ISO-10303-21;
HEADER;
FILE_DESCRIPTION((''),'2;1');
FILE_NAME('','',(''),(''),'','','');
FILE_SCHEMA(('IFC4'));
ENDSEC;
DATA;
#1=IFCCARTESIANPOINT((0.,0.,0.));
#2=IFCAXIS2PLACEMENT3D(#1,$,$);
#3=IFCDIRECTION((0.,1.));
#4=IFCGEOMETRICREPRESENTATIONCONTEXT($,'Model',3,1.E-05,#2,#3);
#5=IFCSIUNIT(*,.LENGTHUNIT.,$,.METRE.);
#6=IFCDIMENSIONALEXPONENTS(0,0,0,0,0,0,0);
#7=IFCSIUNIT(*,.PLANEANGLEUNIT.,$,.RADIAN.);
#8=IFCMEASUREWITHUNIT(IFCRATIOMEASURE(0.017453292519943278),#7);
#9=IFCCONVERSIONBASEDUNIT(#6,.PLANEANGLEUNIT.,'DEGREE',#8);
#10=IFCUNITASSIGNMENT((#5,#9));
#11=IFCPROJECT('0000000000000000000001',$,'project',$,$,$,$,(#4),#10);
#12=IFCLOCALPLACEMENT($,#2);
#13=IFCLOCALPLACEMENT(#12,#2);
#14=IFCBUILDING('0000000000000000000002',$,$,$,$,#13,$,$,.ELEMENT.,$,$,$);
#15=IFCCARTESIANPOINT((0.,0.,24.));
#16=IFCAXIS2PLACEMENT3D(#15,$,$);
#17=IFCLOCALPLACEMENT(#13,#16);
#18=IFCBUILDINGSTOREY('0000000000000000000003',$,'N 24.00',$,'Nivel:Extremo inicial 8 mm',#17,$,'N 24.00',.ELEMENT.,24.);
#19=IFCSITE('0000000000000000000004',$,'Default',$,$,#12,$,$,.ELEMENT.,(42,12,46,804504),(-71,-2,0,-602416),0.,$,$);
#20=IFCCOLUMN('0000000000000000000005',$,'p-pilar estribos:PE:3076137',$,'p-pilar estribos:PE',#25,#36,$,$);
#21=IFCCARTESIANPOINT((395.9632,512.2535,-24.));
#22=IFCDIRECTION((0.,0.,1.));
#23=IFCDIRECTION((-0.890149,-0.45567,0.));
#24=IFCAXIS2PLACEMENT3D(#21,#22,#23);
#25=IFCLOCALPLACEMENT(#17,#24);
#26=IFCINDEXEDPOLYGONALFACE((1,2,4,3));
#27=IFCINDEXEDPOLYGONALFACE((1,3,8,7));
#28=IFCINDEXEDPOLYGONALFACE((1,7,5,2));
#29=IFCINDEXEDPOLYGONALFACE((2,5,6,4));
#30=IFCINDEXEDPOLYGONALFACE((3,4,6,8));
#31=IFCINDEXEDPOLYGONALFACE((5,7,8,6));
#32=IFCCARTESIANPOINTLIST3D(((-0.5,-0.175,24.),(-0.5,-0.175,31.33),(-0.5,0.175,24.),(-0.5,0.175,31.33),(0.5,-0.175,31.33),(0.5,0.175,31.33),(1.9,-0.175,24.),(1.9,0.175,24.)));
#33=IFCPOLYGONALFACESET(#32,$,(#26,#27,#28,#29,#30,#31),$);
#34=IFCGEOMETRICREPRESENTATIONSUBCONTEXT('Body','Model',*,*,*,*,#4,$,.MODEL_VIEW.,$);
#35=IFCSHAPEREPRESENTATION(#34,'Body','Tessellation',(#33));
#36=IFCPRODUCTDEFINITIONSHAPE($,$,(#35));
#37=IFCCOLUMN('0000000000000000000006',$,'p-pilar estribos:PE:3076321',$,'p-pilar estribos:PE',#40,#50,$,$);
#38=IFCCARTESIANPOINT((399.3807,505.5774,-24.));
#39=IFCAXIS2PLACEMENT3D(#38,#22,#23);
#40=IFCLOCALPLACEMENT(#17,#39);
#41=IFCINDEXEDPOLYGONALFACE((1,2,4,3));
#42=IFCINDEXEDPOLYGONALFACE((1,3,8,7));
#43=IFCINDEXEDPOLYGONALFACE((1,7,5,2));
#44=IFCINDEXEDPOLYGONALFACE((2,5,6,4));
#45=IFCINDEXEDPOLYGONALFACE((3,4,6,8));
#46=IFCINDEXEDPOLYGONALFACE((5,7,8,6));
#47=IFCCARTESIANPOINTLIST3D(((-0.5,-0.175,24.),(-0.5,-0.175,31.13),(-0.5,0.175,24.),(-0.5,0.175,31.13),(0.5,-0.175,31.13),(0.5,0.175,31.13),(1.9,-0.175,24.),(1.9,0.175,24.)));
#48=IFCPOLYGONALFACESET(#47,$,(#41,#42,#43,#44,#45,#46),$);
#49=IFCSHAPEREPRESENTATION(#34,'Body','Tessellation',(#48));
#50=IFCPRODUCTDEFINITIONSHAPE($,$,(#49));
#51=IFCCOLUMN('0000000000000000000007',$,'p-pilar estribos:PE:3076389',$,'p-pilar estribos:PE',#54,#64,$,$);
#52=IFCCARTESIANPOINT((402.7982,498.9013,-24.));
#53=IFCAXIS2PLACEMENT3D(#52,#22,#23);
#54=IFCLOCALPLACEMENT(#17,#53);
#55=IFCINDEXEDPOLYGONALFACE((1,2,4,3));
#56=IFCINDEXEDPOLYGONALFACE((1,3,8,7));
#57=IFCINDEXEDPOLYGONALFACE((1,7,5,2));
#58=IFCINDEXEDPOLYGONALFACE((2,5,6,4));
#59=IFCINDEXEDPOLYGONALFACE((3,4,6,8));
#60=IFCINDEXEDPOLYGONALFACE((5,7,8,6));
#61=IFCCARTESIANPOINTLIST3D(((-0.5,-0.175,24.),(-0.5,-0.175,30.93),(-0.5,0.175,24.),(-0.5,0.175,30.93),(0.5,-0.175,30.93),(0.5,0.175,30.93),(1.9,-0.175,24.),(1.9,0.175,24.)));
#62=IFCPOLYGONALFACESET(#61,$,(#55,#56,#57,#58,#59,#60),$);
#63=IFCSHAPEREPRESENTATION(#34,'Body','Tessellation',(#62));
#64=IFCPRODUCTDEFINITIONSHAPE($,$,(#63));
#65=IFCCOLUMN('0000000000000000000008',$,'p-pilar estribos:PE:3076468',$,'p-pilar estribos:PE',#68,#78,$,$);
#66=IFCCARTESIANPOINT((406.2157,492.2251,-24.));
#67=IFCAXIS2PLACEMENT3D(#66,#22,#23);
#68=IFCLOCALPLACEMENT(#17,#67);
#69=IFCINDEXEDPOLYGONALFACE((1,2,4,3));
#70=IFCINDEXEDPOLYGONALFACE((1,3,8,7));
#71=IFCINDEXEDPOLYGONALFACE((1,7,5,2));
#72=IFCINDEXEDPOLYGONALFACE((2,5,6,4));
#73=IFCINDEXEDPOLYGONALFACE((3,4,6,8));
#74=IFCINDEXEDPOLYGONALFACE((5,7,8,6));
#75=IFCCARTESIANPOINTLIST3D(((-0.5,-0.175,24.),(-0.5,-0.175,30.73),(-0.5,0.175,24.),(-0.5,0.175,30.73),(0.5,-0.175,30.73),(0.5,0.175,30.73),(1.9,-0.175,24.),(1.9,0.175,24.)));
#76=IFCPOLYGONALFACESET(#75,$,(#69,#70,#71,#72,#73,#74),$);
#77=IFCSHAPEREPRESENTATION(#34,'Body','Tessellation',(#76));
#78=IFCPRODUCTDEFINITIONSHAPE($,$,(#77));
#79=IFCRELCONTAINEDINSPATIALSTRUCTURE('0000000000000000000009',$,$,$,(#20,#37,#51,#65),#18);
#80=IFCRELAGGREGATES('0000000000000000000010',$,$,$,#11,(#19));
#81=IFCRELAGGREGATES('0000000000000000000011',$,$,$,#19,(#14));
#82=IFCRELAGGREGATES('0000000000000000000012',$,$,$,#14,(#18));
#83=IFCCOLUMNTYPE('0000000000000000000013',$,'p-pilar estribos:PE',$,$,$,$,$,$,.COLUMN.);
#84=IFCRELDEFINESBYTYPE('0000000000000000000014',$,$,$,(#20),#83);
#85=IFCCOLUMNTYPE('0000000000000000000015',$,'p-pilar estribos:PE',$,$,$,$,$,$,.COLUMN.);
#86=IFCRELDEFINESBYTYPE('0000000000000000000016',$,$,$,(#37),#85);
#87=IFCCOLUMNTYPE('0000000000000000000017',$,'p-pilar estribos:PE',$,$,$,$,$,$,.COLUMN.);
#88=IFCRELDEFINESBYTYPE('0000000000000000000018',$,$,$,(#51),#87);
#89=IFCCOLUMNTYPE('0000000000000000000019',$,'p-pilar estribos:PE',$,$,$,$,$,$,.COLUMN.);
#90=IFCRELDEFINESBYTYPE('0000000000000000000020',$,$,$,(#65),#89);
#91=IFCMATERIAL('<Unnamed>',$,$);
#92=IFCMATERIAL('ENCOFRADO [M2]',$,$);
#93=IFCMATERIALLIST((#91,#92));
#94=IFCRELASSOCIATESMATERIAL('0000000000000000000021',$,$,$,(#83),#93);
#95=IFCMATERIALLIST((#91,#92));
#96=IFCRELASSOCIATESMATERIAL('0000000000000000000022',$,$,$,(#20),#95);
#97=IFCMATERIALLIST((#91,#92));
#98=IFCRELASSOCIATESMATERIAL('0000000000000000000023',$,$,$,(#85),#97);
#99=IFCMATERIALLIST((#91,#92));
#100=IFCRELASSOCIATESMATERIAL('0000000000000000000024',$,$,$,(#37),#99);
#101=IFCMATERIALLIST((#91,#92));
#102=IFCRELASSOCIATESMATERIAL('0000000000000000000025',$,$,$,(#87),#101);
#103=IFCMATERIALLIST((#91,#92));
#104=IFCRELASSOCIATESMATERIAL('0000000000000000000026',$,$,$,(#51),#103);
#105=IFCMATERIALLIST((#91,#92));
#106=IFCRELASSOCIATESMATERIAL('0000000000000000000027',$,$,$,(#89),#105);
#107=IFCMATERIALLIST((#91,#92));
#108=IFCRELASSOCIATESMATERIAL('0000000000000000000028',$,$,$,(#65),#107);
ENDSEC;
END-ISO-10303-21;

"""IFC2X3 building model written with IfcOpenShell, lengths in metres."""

from ifc_helpers import new_model, entity, si_unit, converted_unit, direction, frame, origin, origin_2d_with_axis, place, context, subcontext, project, spatial, rectangle, extrude, clip, halfspace, source, transform, mapped, material, material_list, type_object, type_shapes, element, save


model = new_model("IFC2X3")

# Units and contexts
model_context = context("Model", 3, precision=1e-05, world=origin(), true_north=direction((0.0, 1.0)))
body_context = subcontext(model_context, "Body", "Model", "MODEL_VIEW")
ifc_project = project(units=[si_unit("LENGTHUNIT", "METRE"), converted_unit("PLANEANGLEUNIT", "DEGREE", entity("IfcRatioMeasure", 0.017453292519943278), si_unit("PLANEANGLEUNIT", "RADIAN"), dimensions=[0, 0, 0, 0, 0, 0, 0])], contexts=[model_context])

# Site, building, storey
site_placement = place(None, origin())
site = spatial("IfcSite", under=ifc_project, at=site_placement, Name="Default", CompositionType="ELEMENT", RefLatitude=(42, 12, 46, 804504), RefLongitude=(-71, -2, 0, -602416), RefElevation=0.0)
building_placement = place(site_placement, origin())
building = spatial("IfcBuilding", under=site, at=building_placement, CompositionType="ELEMENT")
storey_placement = place(building_placement, frame((0.0, 0.0, 24.0)))
storey = spatial("IfcBuildingStorey", under=building, at=storey_placement, Name="N 24.00", ObjectType="Nivel:Extremo inicial 8 mm", LongName="N 24.00", CompositionType="ELEMENT", Elevation=24.0)

# Columns
ifc_material_1 = material(Name="<Unnamed>")
ifc_material_2 = material(Name="ENCOFRADO [M2]")
ifc_material_list_1 = material_list([ifc_material_1, ifc_material_2])
ifc_material_list_2 = material_list([ifc_material_1, ifc_material_2])
column_type_1 = type_object("IfcColumnType", Name="p-pilar estribos:PE", PredefinedType="COLUMN", material=ifc_material_list_2)
shared_shape_1 = source(origin(), body_context, "Body", "SweptSolid", [
    clip(extrude(rectangle(XDim=0.35, YDim=2.4, at=origin_2d_with_axis()), frame((0.7, 0.0, 24.0), z_axis=(0.0, 0.0, 1.0), x_axis=(0.0, -1.0, 0.0)), (0.0, 0.0, 1.0), 7.33), halfspace(frame((1.9, 0.0, 24.0), z_axis=(0.982245, 0.0, 0.187605), x_axis=(0.0, 1.0, 0.0)), False)),
])
type_shapes(column_type_1, [shared_shape_1])
column_1_placement = place(storey_placement, frame((395.9632, 512.2535, -24.0), z_axis=(0.0, 0.0, 1.0), x_axis=(-0.890149, -0.45567, 0.0)))
element("IfcColumn", 1, at=column_1_placement, inside=storey, type_object=column_type_1, material=ifc_material_list_1, Name="p-pilar estribos:PE:3076137", ObjectType="p-pilar estribos:PE", context=body_context, shape_type="MappedRepresentation", body=[
    mapped(shared_shape_1, transform((0.0, 0.0, 0.0), scale=1.0)),
])
ifc_material_list_3 = material_list([ifc_material_1, ifc_material_2])
ifc_material_list_4 = material_list([ifc_material_1, ifc_material_2])
column_type_2 = type_object("IfcColumnType", Name="p-pilar estribos:PE", PredefinedType="COLUMN", material=ifc_material_list_4)
shared_shape_2 = source(origin(), body_context, "Body", "SweptSolid", [
    clip(extrude(rectangle(XDim=0.35, YDim=2.4, at=origin_2d_with_axis()), frame((0.7, 0.0, 24.0), z_axis=(0.0, 0.0, 1.0), x_axis=(0.0, -1.0, 0.0)), (0.0, 0.0, 1.0), 7.13), halfspace(frame((1.9, 0.0, 24.0), z_axis=(0.981263, 0.0, 0.192674), x_axis=(0.0, 1.0, 0.0)), False)),
])
type_shapes(column_type_2, [shared_shape_2])
column_2_placement = place(storey_placement, frame((399.3807, 505.5774, -24.0), z_axis=(0.0, 0.0, 1.0), x_axis=(-0.890149, -0.45567, 0.0)))
element("IfcColumn", 2, at=column_2_placement, inside=storey, type_object=column_type_2, material=ifc_material_list_3, Name="p-pilar estribos:PE:3076321", ObjectType="p-pilar estribos:PE", context=body_context, shape_type="MappedRepresentation", body=[
    mapped(shared_shape_2, transform((0.0, 0.0, 0.0), scale=1.0)),
])
ifc_material_list_5 = material_list([ifc_material_1, ifc_material_2])
ifc_material_list_6 = material_list([ifc_material_1, ifc_material_2])
column_type_3 = type_object("IfcColumnType", Name="p-pilar estribos:PE", PredefinedType="COLUMN", material=ifc_material_list_6)
shared_shape_3 = source(origin(), body_context, "Body", "SweptSolid", [
    clip(extrude(rectangle(XDim=0.35, YDim=2.4, at=origin_2d_with_axis()), frame((0.7, 0.0, 24.0), z_axis=(0.0, 0.0, 1.0), x_axis=(0.0, -1.0, 0.0)), (0.0, 0.0, 1.0), 6.93), halfspace(frame((1.9, 0.0, 24.0), z_axis=(0.980198, 0.0, 0.19802), x_axis=(0.0, 1.0, 0.0)), False)),
])
type_shapes(column_type_3, [shared_shape_3])
column_3_placement = place(storey_placement, frame((402.7982, 498.9013, -24.0), z_axis=(0.0, 0.0, 1.0), x_axis=(-0.890149, -0.45567, 0.0)))
element("IfcColumn", 3, at=column_3_placement, inside=storey, type_object=column_type_3, material=ifc_material_list_5, Name="p-pilar estribos:PE:3076389", ObjectType="p-pilar estribos:PE", context=body_context, shape_type="MappedRepresentation", body=[
    mapped(shared_shape_3, transform((0.0, 0.0, 0.0), scale=1.0)),
])
ifc_material_list_7 = material_list([ifc_material_1, ifc_material_2])
ifc_material_list_8 = material_list([ifc_material_1, ifc_material_2])
column_type_4 = type_object("IfcColumnType", Name="p-pilar estribos:PE", PredefinedType="COLUMN", material=ifc_material_list_8)
shared_shape_4 = source(origin(), body_context, "Body", "SweptSolid", [
    clip(extrude(rectangle(XDim=0.35, YDim=2.4, at=origin_2d_with_axis()), frame((0.7, 0.0, 24.0), z_axis=(0.0, 0.0, 1.0), x_axis=(0.0, -1.0, 0.0)), (0.0, 0.0, 1.0), 6.73), halfspace(frame((1.9, 0.0, 24.0), z_axis=(0.979041, 0.0, 0.203664), x_axis=(0.0, 1.0, 0.0)), False)),
])
type_shapes(column_type_4, [shared_shape_4])
column_4_placement = place(storey_placement, frame((406.2157, 492.2251, -24.0), z_axis=(0.0, 0.0, 1.0), x_axis=(-0.890149, -0.45567, 0.0)))
element("IfcColumn", 4, at=column_4_placement, inside=storey, type_object=column_type_4, material=ifc_material_list_7, Name="p-pilar estribos:PE:3076468", ObjectType="p-pilar estribos:PE", context=body_context, shape_type="MappedRepresentation", body=[
    mapped(shared_shape_4, transform((0.0, 0.0, 0.0), scale=1.0)),
])

save(model, "model.ifc")
